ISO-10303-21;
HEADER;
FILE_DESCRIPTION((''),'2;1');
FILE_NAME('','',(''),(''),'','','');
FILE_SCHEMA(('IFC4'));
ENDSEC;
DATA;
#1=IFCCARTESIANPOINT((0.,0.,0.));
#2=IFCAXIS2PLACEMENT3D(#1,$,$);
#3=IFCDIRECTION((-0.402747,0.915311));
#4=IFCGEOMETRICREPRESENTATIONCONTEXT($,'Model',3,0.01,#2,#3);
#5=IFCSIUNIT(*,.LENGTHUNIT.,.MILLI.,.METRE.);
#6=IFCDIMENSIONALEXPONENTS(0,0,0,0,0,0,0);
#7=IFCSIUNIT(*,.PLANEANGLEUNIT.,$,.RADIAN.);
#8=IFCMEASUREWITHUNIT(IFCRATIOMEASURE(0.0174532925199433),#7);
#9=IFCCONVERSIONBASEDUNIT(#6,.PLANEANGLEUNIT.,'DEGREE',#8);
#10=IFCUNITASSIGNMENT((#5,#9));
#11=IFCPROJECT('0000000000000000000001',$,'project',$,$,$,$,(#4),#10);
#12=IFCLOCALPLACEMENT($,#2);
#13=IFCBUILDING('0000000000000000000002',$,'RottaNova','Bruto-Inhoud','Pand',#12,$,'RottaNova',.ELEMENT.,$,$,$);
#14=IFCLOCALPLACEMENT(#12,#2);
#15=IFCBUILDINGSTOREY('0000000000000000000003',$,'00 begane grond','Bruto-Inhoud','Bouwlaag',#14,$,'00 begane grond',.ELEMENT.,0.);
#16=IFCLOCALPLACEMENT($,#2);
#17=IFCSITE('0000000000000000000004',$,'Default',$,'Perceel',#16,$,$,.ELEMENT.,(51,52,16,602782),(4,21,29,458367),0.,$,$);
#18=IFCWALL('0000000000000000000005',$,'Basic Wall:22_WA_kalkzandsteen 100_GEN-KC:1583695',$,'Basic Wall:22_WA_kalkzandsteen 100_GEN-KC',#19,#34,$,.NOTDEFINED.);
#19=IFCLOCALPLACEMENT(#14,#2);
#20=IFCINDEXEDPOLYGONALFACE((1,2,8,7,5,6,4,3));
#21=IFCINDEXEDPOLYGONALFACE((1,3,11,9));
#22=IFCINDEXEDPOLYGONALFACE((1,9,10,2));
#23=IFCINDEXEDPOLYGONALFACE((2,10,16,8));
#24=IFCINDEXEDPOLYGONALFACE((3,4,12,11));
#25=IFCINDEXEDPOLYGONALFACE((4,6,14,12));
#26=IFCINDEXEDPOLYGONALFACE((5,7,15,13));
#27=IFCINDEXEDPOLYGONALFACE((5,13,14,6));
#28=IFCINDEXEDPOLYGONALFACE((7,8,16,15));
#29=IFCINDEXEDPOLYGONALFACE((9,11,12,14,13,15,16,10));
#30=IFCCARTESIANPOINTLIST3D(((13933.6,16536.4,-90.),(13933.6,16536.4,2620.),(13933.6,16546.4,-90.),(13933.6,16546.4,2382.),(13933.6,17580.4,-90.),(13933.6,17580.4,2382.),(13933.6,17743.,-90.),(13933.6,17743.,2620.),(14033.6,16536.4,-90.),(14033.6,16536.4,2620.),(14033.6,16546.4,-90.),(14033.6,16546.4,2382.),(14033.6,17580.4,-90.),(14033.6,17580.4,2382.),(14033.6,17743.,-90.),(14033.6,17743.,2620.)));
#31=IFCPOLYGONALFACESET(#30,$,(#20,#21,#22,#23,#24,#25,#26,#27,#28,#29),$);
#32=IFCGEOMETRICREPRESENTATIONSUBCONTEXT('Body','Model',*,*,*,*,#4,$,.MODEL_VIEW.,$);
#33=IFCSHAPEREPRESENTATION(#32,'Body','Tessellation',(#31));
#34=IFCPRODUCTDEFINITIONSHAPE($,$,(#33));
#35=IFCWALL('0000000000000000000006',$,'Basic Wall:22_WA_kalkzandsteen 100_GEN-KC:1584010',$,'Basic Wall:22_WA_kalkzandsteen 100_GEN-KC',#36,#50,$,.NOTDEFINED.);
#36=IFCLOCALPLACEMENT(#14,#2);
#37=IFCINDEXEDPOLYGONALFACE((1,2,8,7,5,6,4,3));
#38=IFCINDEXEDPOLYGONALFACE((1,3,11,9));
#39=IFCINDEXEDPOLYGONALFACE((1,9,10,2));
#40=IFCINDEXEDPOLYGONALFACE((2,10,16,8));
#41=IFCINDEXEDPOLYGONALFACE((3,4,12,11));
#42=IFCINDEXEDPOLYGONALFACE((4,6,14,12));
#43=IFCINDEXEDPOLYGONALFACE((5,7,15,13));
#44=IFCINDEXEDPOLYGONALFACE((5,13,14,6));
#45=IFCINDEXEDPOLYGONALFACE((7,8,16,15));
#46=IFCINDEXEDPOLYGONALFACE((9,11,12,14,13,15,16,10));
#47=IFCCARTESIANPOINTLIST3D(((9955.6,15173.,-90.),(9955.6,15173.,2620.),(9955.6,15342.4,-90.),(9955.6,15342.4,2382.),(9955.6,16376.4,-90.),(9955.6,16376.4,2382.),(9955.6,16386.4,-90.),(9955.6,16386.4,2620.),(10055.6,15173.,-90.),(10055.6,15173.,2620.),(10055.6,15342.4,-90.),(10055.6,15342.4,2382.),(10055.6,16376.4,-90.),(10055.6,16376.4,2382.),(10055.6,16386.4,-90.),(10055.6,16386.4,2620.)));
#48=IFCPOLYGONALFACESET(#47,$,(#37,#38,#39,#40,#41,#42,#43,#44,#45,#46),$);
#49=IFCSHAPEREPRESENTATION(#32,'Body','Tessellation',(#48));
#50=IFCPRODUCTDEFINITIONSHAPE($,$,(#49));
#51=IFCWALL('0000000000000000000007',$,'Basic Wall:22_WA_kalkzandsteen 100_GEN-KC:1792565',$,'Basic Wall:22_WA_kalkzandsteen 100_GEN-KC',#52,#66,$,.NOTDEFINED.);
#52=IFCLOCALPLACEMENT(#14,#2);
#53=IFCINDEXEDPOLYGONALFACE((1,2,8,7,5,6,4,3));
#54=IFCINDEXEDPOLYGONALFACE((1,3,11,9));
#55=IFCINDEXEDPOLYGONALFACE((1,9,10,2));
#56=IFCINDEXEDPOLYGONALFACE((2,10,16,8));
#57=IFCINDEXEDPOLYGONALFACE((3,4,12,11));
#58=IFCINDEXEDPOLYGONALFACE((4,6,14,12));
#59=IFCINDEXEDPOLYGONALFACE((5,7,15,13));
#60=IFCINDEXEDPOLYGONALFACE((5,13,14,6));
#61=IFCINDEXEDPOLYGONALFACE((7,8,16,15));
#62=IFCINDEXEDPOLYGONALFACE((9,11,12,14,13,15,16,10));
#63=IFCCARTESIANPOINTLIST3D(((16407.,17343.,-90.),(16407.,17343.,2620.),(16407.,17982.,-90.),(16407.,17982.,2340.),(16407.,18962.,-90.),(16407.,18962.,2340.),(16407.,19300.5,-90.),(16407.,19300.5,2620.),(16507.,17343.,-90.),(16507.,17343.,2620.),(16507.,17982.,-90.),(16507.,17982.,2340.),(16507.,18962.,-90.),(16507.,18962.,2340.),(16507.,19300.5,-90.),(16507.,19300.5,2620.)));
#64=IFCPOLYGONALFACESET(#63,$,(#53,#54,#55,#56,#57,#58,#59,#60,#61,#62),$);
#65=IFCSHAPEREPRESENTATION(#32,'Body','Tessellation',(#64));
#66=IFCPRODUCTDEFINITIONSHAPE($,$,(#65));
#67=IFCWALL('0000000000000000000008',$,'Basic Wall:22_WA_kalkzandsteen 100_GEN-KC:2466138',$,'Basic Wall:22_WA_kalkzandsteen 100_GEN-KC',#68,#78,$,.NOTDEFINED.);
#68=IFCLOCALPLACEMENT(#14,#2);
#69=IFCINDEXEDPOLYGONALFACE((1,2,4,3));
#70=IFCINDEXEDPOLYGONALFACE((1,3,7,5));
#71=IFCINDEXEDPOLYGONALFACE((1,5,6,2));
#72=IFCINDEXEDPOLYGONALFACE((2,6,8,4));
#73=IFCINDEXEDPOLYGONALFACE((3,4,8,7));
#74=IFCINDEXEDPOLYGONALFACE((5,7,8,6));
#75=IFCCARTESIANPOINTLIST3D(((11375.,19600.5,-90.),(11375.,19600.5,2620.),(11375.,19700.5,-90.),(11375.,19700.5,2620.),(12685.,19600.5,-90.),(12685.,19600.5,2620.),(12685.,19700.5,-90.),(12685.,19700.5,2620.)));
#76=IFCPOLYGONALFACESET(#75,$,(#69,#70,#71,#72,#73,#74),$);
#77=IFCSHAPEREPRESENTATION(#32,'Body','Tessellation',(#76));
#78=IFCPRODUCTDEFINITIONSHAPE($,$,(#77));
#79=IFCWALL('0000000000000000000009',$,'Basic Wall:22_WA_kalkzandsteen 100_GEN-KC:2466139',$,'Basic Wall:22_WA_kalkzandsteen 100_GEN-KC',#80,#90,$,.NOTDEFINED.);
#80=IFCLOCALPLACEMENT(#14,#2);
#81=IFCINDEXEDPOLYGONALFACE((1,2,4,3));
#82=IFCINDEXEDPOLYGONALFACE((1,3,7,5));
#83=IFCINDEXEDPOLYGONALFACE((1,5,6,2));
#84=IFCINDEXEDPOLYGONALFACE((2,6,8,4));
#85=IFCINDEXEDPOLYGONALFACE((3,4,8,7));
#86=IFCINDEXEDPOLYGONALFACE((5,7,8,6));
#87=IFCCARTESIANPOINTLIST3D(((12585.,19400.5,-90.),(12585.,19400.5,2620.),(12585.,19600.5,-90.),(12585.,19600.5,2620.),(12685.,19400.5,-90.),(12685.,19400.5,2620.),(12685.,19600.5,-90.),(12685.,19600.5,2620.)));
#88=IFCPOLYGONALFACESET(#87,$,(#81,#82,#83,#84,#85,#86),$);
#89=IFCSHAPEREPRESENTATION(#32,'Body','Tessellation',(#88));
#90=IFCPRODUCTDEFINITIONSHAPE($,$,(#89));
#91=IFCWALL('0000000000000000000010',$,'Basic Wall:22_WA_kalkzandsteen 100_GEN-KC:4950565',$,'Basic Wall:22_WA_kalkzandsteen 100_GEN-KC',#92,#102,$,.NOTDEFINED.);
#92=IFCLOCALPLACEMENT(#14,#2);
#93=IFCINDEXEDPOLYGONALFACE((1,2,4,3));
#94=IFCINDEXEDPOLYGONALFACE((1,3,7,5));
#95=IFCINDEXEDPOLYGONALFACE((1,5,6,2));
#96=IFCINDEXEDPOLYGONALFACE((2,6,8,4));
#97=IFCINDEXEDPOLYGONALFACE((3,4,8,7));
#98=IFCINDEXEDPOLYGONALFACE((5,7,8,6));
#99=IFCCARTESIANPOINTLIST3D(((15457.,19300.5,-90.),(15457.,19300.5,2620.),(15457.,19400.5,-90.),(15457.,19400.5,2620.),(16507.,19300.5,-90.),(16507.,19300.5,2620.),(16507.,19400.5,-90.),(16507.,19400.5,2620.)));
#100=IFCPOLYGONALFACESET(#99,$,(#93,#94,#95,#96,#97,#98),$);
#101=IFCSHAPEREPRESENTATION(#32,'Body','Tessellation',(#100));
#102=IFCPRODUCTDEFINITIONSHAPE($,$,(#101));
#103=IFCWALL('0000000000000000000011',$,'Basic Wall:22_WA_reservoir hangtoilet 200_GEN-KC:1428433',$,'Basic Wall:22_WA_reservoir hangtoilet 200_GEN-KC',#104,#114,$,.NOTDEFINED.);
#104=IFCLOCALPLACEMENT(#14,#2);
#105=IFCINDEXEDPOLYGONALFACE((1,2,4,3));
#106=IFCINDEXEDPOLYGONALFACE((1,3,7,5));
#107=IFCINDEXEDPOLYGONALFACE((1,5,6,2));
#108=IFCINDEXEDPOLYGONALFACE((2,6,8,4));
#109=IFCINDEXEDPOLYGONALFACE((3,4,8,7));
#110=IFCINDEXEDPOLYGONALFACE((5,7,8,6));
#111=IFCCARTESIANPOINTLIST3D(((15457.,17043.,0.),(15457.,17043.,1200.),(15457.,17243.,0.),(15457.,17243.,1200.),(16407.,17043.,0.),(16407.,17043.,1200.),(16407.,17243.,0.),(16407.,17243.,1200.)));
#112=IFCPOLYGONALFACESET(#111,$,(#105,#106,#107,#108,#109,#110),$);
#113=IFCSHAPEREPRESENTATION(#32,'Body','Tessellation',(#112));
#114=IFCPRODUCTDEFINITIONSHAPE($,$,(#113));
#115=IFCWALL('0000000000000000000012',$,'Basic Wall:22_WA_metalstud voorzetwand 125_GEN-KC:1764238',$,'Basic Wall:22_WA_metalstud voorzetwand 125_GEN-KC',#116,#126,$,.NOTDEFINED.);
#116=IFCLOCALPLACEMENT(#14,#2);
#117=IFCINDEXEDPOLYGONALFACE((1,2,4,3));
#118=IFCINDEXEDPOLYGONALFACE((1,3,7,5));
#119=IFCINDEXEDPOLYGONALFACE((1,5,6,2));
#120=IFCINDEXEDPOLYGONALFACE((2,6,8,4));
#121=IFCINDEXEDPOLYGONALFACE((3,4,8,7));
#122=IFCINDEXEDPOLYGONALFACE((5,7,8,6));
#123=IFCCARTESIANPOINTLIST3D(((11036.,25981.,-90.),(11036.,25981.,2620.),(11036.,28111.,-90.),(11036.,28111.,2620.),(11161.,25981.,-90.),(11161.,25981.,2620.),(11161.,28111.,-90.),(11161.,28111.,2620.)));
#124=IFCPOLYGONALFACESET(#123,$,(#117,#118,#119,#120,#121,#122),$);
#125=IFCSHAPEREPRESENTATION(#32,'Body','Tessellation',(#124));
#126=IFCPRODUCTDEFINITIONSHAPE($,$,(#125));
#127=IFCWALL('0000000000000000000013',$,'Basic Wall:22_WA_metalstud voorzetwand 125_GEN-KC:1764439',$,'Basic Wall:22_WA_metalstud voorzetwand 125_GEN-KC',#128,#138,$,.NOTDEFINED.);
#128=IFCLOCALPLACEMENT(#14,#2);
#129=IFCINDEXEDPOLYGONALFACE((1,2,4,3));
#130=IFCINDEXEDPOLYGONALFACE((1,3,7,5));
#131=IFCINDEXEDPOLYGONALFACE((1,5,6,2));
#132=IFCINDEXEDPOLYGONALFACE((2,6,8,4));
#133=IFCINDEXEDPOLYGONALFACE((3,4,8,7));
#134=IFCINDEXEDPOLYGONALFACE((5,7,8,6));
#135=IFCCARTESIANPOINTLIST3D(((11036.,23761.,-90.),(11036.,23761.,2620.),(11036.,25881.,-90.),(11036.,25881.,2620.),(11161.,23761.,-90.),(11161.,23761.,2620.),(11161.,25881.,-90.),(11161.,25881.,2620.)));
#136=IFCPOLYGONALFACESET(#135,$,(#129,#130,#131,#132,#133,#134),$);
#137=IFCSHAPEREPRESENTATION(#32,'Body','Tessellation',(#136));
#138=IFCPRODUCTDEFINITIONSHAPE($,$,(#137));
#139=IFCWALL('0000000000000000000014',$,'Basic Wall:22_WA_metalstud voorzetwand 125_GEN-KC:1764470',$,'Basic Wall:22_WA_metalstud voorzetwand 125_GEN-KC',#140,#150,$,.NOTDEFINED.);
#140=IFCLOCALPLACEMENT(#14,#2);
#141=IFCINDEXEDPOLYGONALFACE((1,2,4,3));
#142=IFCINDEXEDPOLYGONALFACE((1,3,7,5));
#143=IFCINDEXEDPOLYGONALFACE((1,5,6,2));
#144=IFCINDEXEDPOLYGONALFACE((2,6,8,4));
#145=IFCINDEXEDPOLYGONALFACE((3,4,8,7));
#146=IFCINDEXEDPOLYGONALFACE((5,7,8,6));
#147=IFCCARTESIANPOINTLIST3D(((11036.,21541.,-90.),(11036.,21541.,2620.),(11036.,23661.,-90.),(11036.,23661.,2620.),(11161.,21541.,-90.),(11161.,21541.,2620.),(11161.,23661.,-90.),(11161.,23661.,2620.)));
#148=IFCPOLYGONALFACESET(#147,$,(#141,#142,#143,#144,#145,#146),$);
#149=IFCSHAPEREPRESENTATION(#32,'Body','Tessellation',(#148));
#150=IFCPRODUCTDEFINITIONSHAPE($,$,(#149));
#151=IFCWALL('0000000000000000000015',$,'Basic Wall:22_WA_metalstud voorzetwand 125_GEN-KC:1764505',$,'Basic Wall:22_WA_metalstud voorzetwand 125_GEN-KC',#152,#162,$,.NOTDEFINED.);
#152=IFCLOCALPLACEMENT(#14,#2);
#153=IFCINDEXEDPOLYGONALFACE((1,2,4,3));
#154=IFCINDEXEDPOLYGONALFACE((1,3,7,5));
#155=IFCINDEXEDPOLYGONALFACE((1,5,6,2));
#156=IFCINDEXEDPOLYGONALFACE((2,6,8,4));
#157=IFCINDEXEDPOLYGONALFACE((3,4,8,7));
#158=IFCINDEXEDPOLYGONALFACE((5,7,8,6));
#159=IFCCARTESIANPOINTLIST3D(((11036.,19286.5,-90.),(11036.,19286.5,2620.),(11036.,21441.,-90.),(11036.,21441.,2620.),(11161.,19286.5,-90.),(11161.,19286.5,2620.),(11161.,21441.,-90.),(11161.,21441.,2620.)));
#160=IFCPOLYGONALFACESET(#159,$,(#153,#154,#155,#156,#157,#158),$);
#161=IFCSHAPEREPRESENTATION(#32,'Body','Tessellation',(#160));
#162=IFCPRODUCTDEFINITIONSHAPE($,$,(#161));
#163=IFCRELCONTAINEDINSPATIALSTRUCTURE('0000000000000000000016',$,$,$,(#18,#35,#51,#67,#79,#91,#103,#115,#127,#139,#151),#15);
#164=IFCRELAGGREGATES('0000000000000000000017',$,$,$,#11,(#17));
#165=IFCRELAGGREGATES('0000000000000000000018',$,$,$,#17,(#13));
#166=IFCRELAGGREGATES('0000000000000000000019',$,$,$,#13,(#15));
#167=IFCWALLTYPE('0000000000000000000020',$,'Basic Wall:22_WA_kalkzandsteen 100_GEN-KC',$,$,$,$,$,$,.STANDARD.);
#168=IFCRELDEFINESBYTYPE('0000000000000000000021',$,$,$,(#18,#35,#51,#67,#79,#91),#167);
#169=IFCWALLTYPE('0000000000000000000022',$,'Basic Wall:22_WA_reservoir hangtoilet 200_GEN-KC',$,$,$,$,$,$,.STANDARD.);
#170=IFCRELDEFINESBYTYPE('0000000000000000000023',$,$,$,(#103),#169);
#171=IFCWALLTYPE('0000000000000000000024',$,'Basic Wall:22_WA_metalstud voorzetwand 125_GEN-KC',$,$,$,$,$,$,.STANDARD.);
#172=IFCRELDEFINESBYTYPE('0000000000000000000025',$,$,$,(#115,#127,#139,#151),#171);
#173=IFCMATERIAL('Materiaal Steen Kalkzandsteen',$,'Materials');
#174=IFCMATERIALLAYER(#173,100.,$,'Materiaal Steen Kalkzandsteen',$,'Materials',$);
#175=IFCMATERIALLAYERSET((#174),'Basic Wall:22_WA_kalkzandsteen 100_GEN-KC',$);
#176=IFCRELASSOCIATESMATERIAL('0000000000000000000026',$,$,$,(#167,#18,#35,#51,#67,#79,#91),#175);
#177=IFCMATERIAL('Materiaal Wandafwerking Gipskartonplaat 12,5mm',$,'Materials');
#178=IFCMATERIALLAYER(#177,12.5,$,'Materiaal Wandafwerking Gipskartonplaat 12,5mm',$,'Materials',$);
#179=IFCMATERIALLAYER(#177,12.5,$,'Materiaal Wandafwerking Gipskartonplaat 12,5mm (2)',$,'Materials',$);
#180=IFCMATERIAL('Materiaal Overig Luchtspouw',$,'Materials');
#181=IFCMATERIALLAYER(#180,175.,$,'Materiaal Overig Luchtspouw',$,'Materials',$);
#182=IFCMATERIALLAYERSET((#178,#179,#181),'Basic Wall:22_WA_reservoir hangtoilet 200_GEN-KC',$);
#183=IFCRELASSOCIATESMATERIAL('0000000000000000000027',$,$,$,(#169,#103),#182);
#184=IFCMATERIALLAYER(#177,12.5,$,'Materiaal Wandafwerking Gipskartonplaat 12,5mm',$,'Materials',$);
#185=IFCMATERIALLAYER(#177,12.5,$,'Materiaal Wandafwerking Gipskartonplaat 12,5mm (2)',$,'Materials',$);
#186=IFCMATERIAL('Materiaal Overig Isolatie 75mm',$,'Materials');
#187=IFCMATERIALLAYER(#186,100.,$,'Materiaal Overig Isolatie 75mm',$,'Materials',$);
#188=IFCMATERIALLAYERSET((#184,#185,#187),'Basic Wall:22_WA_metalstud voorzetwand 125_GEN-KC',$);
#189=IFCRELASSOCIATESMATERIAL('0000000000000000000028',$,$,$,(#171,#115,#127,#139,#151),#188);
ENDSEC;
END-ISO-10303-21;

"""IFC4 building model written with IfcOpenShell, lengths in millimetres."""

from ifc_helpers import new_model, entity, si_unit, converted_unit, direction, frame, frame_2d, origin, place, context, subcontext, project, spatial, rectangle, extrude, material, layer, layer_set, type_object, element, save


model = new_model("IFC4")

# Units and contexts
model_context = context("Model", 3, precision=0.01, world=origin(), true_north=direction((-0.402747, 0.915311)))
body_context = subcontext(model_context, "Body", "Model", "MODEL_VIEW")
ifc_project = project(units=[si_unit("LENGTHUNIT", "METRE", prefix="MILLI"), converted_unit("PLANEANGLEUNIT", "DEGREE", entity("IfcRatioMeasure", 0.0174532925199433), si_unit("PLANEANGLEUNIT", "RADIAN"), dimensions=[0, 0, 0, 0, 0, 0, 0])], contexts=[model_context])

# Site, building, storey
site_placement = place(None, origin())
site = spatial("IfcSite", under=ifc_project, at=site_placement, Name="Default", ObjectType="Perceel", CompositionType="ELEMENT", RefLatitude=(51, 52, 16, 602782), RefLongitude=(4, 21, 29, 458367), RefElevation=0.0)
building_placement = place(None, origin())
building = spatial("IfcBuilding", under=site, at=building_placement, Name="RottaNova", Description="Bruto-Inhoud", ObjectType="Pand", LongName="RottaNova", CompositionType="ELEMENT")
storey_placement = place(building_placement, origin())
storey = spatial("IfcBuildingStorey", under=building, at=storey_placement, Name="00 begane grond", Description="Bruto-Inhoud", ObjectType="Bouwlaag", LongName="00 begane grond", CompositionType="ELEMENT", Elevation=0.0)

# Shared definitions
ifc_material_1 = material(Name="Materiaal Steen Kalkzandsteen", Category="Materials")

# Shared definitions
ifc_material_2 = material(Name="Materiaal Wandafwerking Gipskartonplaat 12,5mm", Category="Materials")
ifc_layer_1 = layer(ifc_material_1, 100.0, Name="Materiaal Steen Kalkzandsteen", Category="Materials")
ifc_layer_set_1 = layer_set([ifc_layer_1], Name="Basic Wall:22_WA_kalkzandsteen 100_GEN-KC")
wall_type_1 = type_object("IfcWallType", Name="Basic Wall:22_WA_kalkzandsteen 100_GEN-KC", PredefinedType="STANDARD", material=ifc_layer_set_1)

# Walls, openings
wall_1_placement = place(storey_placement, frame((13983.6, 16536.4, -90.0), z_axis=(0.0, 0.0, 1.0), x_axis=(0.0, 1.0, 0.0)))
wall_1 = element("IfcWall", 1, at=wall_1_placement, inside=storey, type_object=wall_type_1, material=ifc_layer_set_1, Name="Basic Wall:22_WA_kalkzandsteen 100_GEN-KC:1583695", ObjectType="Basic Wall:22_WA_kalkzandsteen 100_GEN-KC", PredefinedType="NOTDEFINED", context=body_context, shape_type="SweptSolid", body=[
    extrude(rectangle(XDim=1206.6, YDim=100.0, at=frame_2d((603.3, 0.0), x_axis=(1.0, 0.0))), origin(), (0.0, 0.0, 1.0), 2710.0),
])
opening_1_placement = place(wall_1_placement, frame((1044.0, 50.0, 0.0)))
element("IfcOpeningElement", 2, at=opening_1_placement, cuts=wall_1, PredefinedType="OPENING", context=body_context, shape_type="SweptSolid", body=[
    extrude(rectangle(XDim=2472.0, YDim=1034.0, at=frame_2d((1236.0, 517.0), x_axis=(1.0, 0.0))), frame((0.0, 0.0, 0.0), z_axis=(0.0, -1.0, 0.0), x_axis=(0.0, 0.0, 1.0)), (0.0, 0.0, 1.0), 100.0),
])
wall_2_placement = place(storey_placement, frame((10005.6, 16386.4, -90.0), z_axis=(0.0, 0.0, 1.0), x_axis=(0.0, -1.0, 0.0)))
wall_2 = element("IfcWall", 3, at=wall_2_placement, inside=storey, type_object=wall_type_1, material=ifc_layer_set_1, Name="Basic Wall:22_WA_kalkzandsteen 100_GEN-KC:1584010", ObjectType="Basic Wall:22_WA_kalkzandsteen 100_GEN-KC", PredefinedType="NOTDEFINED", context=body_context, shape_type="SweptSolid", body=[
    extrude(rectangle(XDim=1213.4, YDim=100.0, at=frame_2d((606.7, 0.0), x_axis=(1.0, 0.0))), origin(), (0.0, 0.0, 1.0), 2710.0),
])
opening_2_placement = place(wall_2_placement, frame((1044.0, 50.0, 0.0)))
element("IfcOpeningElement", 4, at=opening_2_placement, cuts=wall_2, PredefinedType="OPENING", context=body_context, shape_type="SweptSolid", body=[
    extrude(rectangle(XDim=2472.0, YDim=1034.0, at=frame_2d((1236.0, 517.0), x_axis=(1.0, 0.0))), frame((0.0, 0.0, 0.0), z_axis=(0.0, -1.0, 0.0), x_axis=(0.0, 0.0, 1.0)), (0.0, 0.0, 1.0), 100.0),
])
wall_3_placement = place(storey_placement, frame((16457.0, 19300.5, -90.0), z_axis=(0.0, 0.0, 1.0), x_axis=(0.0, -1.0, 0.0)))
wall_3 = element("IfcWall", 5, at=wall_3_placement, inside=storey, type_object=wall_type_1, material=ifc_layer_set_1, Name="Basic Wall:22_WA_kalkzandsteen 100_GEN-KC:1792565", ObjectType="Basic Wall:22_WA_kalkzandsteen 100_GEN-KC", PredefinedType="NOTDEFINED", context=body_context, shape_type="SweptSolid", body=[
    extrude(rectangle(XDim=1957.5, YDim=100.0, at=frame_2d((978.7, 0.0), x_axis=(1.0, 0.0))), origin(), (0.0, 0.0, 1.0), 2710.0),
])
opening_3_placement = place(wall_3_placement, frame((338.5, -50.0, 0.0)))
element("IfcOpeningElement", 6, at=opening_3_placement, cuts=wall_3, PredefinedType="OPENING", context=body_context, shape_type="SweptSolid", body=[
    extrude(rectangle(XDim=2430.0, YDim=980.0, at=frame_2d((1215.0, 490.0), x_axis=(1.0, 0.0))), frame((0.0, 0.0, 0.0), z_axis=(0.0, 1.0, 0.0), x_axis=(0.0, 0.0, 1.0)), (0.0, 0.0, 1.0), 100.0),
])

# Walls
wall_4_placement = place(storey_placement, frame((11375.0, 19650.5, -90.0)))
element("IfcWall", 7, at=wall_4_placement, inside=storey, type_object=wall_type_1, material=ifc_layer_set_1, Name="Basic Wall:22_WA_kalkzandsteen 100_GEN-KC:2466138", ObjectType="Basic Wall:22_WA_kalkzandsteen 100_GEN-KC", PredefinedType="NOTDEFINED", context=body_context, shape_type="SweptSolid", body=[
    extrude(rectangle(XDim=1310.0, YDim=100.0, at=frame_2d((655.0, 0.0), x_axis=(-1.0, 0.0))), origin(), (0.0, 0.0, 1.0), 2710.0),
])
wall_5_placement = place(storey_placement, frame((12635.0, 19600.5, -90.0), z_axis=(0.0, 0.0, 1.0), x_axis=(0.0, -1.0, 0.0)))
element("IfcWall", 8, at=wall_5_placement, inside=storey, type_object=wall_type_1, material=ifc_layer_set_1, Name="Basic Wall:22_WA_kalkzandsteen 100_GEN-KC:2466139", ObjectType="Basic Wall:22_WA_kalkzandsteen 100_GEN-KC", PredefinedType="NOTDEFINED", context=body_context, shape_type="SweptSolid", body=[
    extrude(rectangle(XDim=200.0, YDim=100.0, at=frame_2d((100.0, 0.0), x_axis=(-1.0, 0.0))), origin(), (0.0, 0.0, 1.0), 2710.0),
])
wall_6_placement = place(storey_placement, frame((16507.0, 19350.5, -90.0), z_axis=(0.0, 0.0, 1.0), x_axis=(-1.0, 0.0, 0.0)))
element("IfcWall", 9, at=wall_6_placement, inside=storey, type_object=wall_type_1, material=ifc_layer_set_1, Name="Basic Wall:22_WA_kalkzandsteen 100_GEN-KC:4950565", ObjectType="Basic Wall:22_WA_kalkzandsteen 100_GEN-KC", PredefinedType="NOTDEFINED", context=body_context, shape_type="SweptSolid", body=[
    extrude(rectangle(XDim=1050.0, YDim=100.0, at=frame_2d((525.0, 0.0), x_axis=(-1.0, 0.0))), origin(), (0.0, 0.0, 1.0), 2710.0),
])
ifc_layer_2 = layer(ifc_material_2, 12.5, Name="Materiaal Wandafwerking Gipskartonplaat 12,5mm", Category="Materials")
ifc_layer_3 = layer(ifc_material_2, 12.5, Name="Materiaal Wandafwerking Gipskartonplaat 12,5mm (2)", Category="Materials")
ifc_material_3 = material(Name="Materiaal Overig Luchtspouw", Category="Materials")
ifc_layer_4 = layer(ifc_material_3, 175.0, Name="Materiaal Overig Luchtspouw", Category="Materials")
ifc_layer_set_2 = layer_set([ifc_layer_2, ifc_layer_3, ifc_layer_4], Name="Basic Wall:22_WA_reservoir hangtoilet 200_GEN-KC")
wall_type_2 = type_object("IfcWallType", Name="Basic Wall:22_WA_reservoir hangtoilet 200_GEN-KC", PredefinedType="STANDARD", material=ifc_layer_set_2)
wall_7_placement = place(storey_placement, frame((16407.0, 17143.0, 0.0), z_axis=(0.0, 0.0, 1.0), x_axis=(-1.0, 0.0, 0.0)))
element("IfcWall", 10, at=wall_7_placement, inside=storey, type_object=wall_type_2, material=ifc_layer_set_2, Name="Basic Wall:22_WA_reservoir hangtoilet 200_GEN-KC:1428433", ObjectType="Basic Wall:22_WA_reservoir hangtoilet 200_GEN-KC", PredefinedType="NOTDEFINED", context=body_context, shape_type="SweptSolid", body=[
    extrude(rectangle(XDim=950.0, YDim=200.0, at=frame_2d((475.0, 0.0), x_axis=(-1.0, 0.0))), origin(), (0.0, 0.0, 1.0), 1200.0),
])
ifc_layer_5 = layer(ifc_material_2, 12.5, Name="Materiaal Wandafwerking Gipskartonplaat 12,5mm", Category="Materials")
ifc_layer_6 = layer(ifc_material_2, 12.5, Name="Materiaal Wandafwerking Gipskartonplaat 12,5mm (2)", Category="Materials")
ifc_material_4 = material(Name="Materiaal Overig Isolatie 75mm", Category="Materials")
ifc_layer_7 = layer(ifc_material_4, 100.0, Name="Materiaal Overig Isolatie 75mm", Category="Materials")
ifc_layer_set_3 = layer_set([ifc_layer_5, ifc_layer_6, ifc_layer_7], Name="Basic Wall:22_WA_metalstud voorzetwand 125_GEN-KC")
wall_type_3 = type_object("IfcWallType", Name="Basic Wall:22_WA_metalstud voorzetwand 125_GEN-KC", PredefinedType="STANDARD", material=ifc_layer_set_3)
wall_8_placement = place(storey_placement, frame((11098.5, 28111.0, -90.0), z_axis=(0.0, 0.0, 1.0), x_axis=(0.0, -1.0, 0.0)))
element("IfcWall", 11, at=wall_8_placement, inside=storey, type_object=wall_type_3, material=ifc_layer_set_3, Name="Basic Wall:22_WA_metalstud voorzetwand 125_GEN-KC:1764238", ObjectType="Basic Wall:22_WA_metalstud voorzetwand 125_GEN-KC", PredefinedType="NOTDEFINED", context=body_context, shape_type="SweptSolid", body=[
    extrude(rectangle(XDim=2130.0, YDim=125.0, at=frame_2d((1065.0, 0.0), x_axis=(-1.0, 0.0))), origin(), (0.0, 0.0, 1.0), 2710.0),
])
for number, where, z_axis, x_axis, name in (
    (12, (11098.5, 25881.0, -90.0), (0.0, 0.0, 1.0), (0.0, -1.0, 0.0), "Basic Wall:22_WA_metalstud voorzetwand 125_GEN-KC:1764439"),
    (13, (11098.5, 23661.0, -90.0), (0.0, 0.0, 1.0), (0.0, -1.0, 0.0), "Basic Wall:22_WA_metalstud voorzetwand 125_GEN-KC:1764470"),
):
    element("IfcWall", number, at=place(storey_placement, frame(where, z_axis=z_axis, x_axis=x_axis)), inside=storey, type_object=wall_type_3, material=ifc_layer_set_3, Name=name, ObjectType="Basic Wall:22_WA_metalstud voorzetwand 125_GEN-KC", PredefinedType="NOTDEFINED", context=body_context, shape_type="SweptSolid", body=[
        extrude(rectangle(XDim=2120.0, YDim=125.0, at=frame_2d((1060.0, 0.0), x_axis=(-1.0, 0.0))), origin(), (0.0, 0.0, 1.0), 2710.0),
    ])
wall_9_placement = place(storey_placement, frame((11098.5, 21441.0, -90.0), z_axis=(0.0, 0.0, 1.0), x_axis=(0.0, -1.0, 0.0)))
element("IfcWall", 14, at=wall_9_placement, inside=storey, type_object=wall_type_3, material=ifc_layer_set_3, Name="Basic Wall:22_WA_metalstud voorzetwand 125_GEN-KC:1764505", ObjectType="Basic Wall:22_WA_metalstud voorzetwand 125_GEN-KC", PredefinedType="NOTDEFINED", context=body_context, shape_type="SweptSolid", body=[
    extrude(rectangle(XDim=2154.5, YDim=125.0, at=frame_2d((1077.2, 0.0), x_axis=(-1.0, 0.0))), origin(), (0.0, 0.0, 1.0), 2710.0),
])

save(model, "model.ifc")
